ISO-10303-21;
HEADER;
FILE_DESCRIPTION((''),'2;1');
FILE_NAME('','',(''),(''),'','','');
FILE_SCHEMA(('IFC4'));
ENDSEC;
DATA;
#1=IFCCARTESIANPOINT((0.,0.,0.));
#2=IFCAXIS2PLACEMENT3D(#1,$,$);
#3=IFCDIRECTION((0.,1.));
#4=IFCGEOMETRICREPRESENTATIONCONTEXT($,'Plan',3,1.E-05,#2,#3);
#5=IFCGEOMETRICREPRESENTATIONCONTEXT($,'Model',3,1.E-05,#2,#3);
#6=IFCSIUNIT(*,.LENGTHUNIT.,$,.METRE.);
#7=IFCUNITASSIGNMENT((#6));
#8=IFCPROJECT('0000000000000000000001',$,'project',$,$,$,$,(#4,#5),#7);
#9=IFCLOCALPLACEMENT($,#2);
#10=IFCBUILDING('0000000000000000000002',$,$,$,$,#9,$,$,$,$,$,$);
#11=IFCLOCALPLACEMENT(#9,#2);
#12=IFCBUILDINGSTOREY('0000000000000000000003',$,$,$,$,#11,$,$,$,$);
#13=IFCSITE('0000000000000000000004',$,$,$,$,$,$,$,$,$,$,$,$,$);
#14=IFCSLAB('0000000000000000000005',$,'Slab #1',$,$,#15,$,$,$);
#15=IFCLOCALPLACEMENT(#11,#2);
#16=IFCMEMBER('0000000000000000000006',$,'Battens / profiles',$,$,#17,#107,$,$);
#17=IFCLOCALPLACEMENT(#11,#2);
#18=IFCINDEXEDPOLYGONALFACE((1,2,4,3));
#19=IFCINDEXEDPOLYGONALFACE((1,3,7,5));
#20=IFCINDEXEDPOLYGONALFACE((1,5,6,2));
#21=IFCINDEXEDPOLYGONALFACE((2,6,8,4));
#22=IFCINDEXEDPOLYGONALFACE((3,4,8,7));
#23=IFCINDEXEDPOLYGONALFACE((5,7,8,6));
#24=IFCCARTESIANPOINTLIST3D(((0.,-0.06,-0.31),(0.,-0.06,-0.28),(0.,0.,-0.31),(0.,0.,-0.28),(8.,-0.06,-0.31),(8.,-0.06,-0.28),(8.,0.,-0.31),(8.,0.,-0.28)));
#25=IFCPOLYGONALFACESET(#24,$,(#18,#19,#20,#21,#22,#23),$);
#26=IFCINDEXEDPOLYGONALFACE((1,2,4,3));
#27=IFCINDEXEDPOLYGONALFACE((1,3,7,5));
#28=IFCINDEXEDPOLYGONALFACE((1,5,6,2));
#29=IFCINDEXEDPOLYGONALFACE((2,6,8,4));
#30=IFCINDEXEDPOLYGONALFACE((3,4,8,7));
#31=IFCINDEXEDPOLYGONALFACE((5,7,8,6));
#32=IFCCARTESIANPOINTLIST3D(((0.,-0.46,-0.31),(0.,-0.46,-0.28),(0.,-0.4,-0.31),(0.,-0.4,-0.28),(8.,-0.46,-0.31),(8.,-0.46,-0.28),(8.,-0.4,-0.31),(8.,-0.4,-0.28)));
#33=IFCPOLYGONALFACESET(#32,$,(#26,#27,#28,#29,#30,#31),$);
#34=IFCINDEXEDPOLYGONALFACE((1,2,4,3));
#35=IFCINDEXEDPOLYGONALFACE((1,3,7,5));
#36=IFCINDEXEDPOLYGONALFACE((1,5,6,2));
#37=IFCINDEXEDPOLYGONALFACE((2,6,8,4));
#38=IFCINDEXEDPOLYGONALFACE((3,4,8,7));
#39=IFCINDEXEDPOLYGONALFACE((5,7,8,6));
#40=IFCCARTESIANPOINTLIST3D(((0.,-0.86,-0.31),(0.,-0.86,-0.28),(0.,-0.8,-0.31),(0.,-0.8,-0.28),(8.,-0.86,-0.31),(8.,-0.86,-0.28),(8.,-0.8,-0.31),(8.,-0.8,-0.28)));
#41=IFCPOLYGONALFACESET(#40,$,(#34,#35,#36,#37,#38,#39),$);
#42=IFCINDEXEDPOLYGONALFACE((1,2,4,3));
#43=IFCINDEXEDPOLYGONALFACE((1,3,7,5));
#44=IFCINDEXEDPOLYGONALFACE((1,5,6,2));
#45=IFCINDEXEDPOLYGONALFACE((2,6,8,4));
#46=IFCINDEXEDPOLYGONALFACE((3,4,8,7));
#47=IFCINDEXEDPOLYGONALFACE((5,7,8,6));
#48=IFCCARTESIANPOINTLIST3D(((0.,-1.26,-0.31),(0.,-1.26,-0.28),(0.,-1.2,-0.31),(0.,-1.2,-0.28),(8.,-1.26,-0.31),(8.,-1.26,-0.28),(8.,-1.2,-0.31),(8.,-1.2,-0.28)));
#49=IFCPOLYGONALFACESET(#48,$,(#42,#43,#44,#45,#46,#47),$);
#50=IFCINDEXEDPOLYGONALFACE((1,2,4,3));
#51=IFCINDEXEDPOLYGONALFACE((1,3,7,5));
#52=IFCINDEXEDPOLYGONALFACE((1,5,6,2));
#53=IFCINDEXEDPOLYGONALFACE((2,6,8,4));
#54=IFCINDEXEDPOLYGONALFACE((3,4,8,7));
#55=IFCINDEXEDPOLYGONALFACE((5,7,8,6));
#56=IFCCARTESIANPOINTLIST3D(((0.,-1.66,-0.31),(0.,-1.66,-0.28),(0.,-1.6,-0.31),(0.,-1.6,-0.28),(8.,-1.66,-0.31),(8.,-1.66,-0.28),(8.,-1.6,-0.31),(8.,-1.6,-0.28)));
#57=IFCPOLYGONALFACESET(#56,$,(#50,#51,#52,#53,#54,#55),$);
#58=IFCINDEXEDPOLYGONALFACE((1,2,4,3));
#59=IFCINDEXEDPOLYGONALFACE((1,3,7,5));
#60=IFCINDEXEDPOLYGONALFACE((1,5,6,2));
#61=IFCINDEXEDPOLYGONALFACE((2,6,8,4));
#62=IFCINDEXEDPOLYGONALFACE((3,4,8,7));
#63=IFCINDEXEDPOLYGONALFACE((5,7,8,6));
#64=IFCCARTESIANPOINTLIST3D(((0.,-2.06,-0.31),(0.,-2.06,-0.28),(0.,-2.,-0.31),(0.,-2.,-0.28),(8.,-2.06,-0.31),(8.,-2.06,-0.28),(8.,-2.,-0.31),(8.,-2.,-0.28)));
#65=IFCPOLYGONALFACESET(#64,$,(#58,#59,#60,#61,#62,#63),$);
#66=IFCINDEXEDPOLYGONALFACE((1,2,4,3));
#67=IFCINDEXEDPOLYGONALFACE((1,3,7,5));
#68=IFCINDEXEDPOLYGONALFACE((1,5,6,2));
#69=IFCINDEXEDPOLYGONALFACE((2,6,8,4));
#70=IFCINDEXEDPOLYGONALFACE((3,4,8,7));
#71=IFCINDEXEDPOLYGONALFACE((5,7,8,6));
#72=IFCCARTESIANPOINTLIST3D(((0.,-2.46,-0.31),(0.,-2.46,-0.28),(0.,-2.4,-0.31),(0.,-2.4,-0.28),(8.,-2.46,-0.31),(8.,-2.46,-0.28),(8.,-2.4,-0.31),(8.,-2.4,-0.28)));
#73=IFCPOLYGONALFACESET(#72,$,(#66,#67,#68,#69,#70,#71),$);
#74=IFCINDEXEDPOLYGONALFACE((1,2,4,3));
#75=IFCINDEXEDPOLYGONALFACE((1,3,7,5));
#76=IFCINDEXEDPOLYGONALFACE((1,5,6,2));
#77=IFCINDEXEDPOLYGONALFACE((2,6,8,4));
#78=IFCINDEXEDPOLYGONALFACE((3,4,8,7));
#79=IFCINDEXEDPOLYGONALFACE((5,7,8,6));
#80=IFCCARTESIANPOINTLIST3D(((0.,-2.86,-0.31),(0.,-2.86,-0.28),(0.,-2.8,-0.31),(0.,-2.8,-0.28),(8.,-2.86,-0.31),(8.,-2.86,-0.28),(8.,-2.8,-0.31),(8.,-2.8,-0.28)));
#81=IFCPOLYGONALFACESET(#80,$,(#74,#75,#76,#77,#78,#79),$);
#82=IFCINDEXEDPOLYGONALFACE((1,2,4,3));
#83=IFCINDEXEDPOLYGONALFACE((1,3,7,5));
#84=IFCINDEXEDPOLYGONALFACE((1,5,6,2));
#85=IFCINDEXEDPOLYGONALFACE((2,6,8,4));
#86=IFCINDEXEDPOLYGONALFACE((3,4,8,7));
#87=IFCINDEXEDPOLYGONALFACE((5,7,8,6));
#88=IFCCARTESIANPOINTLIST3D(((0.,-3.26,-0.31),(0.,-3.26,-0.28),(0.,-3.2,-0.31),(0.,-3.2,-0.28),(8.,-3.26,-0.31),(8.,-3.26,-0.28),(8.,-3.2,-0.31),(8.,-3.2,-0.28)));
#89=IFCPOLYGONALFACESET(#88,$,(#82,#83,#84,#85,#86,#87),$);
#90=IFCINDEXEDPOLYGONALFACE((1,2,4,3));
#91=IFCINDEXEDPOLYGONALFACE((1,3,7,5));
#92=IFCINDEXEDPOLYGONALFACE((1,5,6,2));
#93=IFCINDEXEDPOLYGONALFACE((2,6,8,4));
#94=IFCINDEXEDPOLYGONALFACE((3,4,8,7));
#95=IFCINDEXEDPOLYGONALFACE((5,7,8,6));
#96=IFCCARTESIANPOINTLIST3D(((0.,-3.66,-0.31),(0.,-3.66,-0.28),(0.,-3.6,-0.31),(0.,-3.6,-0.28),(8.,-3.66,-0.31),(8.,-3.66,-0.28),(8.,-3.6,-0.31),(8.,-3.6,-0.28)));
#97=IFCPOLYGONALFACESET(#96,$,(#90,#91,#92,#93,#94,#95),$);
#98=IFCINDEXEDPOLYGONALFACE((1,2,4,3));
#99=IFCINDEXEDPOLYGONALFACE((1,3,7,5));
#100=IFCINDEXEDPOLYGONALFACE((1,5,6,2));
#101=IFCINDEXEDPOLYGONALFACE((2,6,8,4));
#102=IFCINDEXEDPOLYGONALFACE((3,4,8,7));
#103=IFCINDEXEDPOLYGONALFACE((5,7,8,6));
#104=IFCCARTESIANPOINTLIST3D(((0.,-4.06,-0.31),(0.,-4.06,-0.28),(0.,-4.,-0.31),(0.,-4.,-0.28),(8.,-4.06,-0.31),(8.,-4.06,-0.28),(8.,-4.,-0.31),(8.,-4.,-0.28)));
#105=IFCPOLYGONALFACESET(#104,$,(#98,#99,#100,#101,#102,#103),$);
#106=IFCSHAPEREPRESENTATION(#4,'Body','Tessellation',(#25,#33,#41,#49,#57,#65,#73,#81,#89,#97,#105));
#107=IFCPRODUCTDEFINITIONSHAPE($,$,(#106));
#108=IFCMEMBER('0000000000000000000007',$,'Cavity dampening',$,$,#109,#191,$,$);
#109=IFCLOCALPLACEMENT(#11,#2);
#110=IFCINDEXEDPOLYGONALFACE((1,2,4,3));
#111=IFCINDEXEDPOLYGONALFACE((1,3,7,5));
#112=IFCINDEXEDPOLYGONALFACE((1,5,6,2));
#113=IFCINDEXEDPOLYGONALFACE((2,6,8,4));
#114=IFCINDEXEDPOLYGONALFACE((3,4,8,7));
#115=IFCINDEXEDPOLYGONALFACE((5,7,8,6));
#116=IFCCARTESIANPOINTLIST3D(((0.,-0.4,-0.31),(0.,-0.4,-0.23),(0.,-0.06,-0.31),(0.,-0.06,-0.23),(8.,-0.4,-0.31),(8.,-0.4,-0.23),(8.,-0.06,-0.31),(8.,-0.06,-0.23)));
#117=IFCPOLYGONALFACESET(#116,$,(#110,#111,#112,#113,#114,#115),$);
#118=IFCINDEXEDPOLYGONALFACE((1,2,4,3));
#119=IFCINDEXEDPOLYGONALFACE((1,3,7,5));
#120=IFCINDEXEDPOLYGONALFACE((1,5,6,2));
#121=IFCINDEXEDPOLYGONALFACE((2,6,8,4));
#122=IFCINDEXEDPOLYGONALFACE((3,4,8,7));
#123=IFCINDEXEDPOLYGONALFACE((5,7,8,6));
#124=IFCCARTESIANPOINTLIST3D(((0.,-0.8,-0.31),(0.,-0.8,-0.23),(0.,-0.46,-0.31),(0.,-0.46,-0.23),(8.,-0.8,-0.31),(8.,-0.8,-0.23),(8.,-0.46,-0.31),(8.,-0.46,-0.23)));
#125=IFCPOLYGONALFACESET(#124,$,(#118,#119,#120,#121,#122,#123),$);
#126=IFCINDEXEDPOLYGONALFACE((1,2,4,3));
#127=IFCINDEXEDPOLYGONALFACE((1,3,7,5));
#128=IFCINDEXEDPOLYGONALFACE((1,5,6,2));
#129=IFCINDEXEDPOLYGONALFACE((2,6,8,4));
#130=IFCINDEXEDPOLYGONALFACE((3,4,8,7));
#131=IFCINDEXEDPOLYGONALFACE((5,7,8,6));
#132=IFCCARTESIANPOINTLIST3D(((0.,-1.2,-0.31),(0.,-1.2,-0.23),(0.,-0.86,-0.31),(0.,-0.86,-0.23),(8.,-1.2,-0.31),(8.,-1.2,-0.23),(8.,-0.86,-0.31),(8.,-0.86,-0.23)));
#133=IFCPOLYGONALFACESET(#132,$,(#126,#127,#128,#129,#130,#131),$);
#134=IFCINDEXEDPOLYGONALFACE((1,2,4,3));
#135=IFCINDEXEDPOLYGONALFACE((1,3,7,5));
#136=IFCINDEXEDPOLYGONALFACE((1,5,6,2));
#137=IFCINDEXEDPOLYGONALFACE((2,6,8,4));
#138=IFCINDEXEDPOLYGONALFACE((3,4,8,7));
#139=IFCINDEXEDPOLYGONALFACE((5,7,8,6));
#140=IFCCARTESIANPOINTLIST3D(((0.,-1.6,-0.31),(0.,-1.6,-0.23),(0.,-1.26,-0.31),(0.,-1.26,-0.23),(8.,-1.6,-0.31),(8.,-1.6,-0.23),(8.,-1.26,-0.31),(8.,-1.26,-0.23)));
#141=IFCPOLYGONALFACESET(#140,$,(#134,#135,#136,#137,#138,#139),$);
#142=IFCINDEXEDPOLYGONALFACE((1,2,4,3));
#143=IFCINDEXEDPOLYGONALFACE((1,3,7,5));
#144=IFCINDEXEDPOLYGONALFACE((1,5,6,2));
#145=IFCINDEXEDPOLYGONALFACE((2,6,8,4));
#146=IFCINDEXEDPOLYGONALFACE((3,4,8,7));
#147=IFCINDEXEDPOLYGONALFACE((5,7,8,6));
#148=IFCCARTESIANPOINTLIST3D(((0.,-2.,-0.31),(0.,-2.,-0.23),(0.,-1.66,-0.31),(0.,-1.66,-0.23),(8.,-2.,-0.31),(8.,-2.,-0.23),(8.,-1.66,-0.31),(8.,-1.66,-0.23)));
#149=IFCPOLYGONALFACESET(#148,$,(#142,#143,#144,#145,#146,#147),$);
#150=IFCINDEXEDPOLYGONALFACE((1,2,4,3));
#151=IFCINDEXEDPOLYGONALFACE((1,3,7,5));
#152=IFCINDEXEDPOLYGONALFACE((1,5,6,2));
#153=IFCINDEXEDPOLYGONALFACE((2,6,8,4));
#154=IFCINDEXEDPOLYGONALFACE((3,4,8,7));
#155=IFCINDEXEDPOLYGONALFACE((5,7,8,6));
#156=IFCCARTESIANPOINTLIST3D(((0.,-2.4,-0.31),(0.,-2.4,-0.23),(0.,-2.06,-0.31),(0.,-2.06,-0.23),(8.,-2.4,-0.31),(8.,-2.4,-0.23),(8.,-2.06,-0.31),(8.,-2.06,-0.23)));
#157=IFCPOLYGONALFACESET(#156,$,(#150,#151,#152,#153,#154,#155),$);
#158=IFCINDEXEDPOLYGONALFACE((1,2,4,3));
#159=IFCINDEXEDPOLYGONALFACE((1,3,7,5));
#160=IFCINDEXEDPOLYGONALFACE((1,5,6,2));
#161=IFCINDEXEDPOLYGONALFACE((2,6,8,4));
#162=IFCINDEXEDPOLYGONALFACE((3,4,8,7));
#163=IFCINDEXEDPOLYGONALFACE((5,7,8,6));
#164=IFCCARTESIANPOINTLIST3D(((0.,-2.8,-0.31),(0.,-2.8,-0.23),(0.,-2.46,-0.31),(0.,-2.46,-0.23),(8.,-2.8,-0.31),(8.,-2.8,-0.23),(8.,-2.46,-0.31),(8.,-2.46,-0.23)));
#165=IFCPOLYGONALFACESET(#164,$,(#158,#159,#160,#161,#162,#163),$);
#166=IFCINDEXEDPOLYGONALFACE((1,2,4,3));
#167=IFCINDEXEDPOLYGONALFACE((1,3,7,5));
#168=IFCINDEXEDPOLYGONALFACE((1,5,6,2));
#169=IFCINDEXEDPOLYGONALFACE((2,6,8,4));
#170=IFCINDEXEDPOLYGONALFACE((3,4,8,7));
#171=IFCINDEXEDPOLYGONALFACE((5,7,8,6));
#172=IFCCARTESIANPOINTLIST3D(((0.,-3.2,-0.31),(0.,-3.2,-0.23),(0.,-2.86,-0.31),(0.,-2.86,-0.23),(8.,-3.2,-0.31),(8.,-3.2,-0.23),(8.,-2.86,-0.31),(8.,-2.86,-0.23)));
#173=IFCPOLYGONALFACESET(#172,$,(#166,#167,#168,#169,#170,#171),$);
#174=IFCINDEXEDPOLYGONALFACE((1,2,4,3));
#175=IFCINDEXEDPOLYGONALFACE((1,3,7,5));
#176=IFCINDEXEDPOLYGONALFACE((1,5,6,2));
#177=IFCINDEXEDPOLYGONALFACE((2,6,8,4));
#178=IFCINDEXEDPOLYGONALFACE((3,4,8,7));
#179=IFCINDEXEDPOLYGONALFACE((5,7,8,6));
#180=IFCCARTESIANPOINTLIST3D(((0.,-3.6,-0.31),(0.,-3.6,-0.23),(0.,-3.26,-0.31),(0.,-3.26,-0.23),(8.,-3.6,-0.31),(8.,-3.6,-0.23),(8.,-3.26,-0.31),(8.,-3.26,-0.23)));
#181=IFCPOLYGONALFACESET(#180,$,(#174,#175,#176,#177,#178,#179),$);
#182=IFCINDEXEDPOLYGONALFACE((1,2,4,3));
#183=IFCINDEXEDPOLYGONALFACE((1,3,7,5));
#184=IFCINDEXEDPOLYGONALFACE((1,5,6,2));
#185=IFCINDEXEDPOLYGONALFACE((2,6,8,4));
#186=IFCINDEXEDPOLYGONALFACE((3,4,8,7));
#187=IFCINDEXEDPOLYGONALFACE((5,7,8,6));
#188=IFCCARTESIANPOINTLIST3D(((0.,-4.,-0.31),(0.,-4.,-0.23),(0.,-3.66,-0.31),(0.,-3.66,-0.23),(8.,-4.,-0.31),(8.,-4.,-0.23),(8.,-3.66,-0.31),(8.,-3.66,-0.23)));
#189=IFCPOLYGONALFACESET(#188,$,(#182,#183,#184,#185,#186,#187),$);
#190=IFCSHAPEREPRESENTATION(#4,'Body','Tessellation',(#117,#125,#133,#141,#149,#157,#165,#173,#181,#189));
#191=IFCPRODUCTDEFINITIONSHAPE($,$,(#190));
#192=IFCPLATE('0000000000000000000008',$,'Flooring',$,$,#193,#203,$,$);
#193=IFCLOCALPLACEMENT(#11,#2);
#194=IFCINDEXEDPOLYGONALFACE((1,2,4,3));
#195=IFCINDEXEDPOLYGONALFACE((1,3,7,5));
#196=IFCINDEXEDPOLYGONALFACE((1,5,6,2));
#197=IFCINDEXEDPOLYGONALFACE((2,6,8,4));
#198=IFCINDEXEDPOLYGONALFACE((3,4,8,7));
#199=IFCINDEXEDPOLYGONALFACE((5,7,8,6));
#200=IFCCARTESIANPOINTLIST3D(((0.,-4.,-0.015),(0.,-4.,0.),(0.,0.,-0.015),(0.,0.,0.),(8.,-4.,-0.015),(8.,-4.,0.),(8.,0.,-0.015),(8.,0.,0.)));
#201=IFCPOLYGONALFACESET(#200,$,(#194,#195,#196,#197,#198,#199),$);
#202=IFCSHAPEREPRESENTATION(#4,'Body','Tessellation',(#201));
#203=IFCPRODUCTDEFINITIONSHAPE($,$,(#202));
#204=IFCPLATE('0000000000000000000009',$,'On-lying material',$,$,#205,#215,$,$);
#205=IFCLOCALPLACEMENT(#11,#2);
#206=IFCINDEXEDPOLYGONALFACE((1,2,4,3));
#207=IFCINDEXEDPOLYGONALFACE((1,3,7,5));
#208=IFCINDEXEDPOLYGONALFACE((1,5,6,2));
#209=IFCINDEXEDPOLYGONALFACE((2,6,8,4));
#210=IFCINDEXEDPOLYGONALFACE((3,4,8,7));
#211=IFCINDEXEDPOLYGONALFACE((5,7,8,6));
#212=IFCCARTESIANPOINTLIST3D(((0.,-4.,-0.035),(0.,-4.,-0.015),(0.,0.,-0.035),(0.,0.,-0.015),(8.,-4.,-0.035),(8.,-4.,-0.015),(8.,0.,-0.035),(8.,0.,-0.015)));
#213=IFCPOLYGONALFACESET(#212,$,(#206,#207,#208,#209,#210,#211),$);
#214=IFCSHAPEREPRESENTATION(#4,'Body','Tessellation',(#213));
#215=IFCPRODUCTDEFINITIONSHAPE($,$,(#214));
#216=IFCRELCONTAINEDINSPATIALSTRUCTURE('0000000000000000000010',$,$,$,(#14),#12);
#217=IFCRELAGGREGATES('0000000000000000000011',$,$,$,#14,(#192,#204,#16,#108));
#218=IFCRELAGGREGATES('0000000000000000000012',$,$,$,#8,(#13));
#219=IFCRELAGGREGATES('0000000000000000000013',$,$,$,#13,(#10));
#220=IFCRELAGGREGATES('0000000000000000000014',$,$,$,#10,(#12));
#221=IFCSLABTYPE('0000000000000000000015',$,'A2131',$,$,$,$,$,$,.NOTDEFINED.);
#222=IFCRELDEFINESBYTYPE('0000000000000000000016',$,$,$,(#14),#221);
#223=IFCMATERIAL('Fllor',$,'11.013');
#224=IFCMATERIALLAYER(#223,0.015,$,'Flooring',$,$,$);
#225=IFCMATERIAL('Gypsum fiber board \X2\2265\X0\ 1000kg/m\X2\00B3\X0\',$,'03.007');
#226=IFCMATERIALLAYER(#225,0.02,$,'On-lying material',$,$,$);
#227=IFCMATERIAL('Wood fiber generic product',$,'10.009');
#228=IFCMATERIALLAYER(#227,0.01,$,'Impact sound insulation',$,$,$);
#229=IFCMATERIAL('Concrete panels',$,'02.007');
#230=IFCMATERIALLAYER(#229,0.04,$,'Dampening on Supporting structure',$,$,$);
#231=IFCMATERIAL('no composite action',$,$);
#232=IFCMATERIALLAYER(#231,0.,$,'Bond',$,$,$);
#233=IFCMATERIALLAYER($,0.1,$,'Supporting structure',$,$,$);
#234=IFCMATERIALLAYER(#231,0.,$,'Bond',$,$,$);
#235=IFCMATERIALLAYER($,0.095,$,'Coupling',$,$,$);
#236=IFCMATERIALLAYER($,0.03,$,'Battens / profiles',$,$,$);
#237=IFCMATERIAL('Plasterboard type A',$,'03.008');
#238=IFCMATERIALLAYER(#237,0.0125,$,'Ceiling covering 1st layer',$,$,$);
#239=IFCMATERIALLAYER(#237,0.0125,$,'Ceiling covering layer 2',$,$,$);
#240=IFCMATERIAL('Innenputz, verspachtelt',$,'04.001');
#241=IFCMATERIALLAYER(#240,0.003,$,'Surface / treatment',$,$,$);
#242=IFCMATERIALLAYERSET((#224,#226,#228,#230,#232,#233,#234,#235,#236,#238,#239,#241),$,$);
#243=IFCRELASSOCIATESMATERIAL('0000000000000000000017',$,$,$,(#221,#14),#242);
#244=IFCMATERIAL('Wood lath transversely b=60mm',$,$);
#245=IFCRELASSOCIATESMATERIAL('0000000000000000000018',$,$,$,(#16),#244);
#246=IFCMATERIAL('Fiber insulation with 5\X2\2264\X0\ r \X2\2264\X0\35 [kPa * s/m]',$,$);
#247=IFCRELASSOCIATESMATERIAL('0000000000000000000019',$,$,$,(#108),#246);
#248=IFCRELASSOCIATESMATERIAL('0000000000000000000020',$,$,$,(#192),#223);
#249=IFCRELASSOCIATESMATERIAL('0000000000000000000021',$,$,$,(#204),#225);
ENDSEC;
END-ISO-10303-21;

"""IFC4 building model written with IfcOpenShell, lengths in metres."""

from ifc_helpers import new_model, si_unit, direction, frame, frame_2d, origin, origin_with_axes, place, context, project, spatial, rectangle, extrude, material, layer, layer_set, type_object, element, aggregate, save


model = new_model("IFC4")

# Units and contexts
plan_context = context("Plan", 3, precision=1e-05, world=origin(), true_north=direction((0.0, 1.0)))
model_context = context("Model", 3, precision=1e-05, world=origin(), true_north=direction((0.0, 1.0)))
ifc_project = project(units=[si_unit("LENGTHUNIT", "METRE")], contexts=[plan_context, model_context])

# Site, building, storey
site = spatial("IfcSite", under=ifc_project)
building_placement = place(None, origin())
building = spatial("IfcBuilding", under=site, at=building_placement)
storey_placement = place(building_placement, origin())
storey = spatial("IfcBuildingStorey", under=building, at=storey_placement)

# Slab, members, plates
ifc_material_1 = material(Name="Fllor", Category="11.013")
ifc_layer_1 = layer(ifc_material_1, 0.015, Name="Flooring")
ifc_material_2 = material(Name="Gypsum fiber board ≥ 1000kg/m³", Category="03.007")
ifc_layer_2 = layer(ifc_material_2, 0.02, Name="On-lying material")
ifc_material_3 = material(Name="Wood fiber generic product", Category="10.009")
ifc_layer_3 = layer(ifc_material_3, 0.01, Name="Impact sound insulation")
ifc_material_4 = material(Name="Concrete panels", Category="02.007")
ifc_layer_4 = layer(ifc_material_4, 0.04, Name="Dampening on Supporting structure")
ifc_material_5 = material(Name="no composite action")
ifc_layer_5 = layer(ifc_material_5, 0.0, Name="Bond")
ifc_layer_6 = layer(None, 0.1, Name="Supporting structure")
ifc_layer_7 = layer(ifc_material_5, 0.0, Name="Bond")
ifc_layer_8 = layer(None, 0.095, Name="Coupling")
ifc_layer_9 = layer(None, 0.03, Name="Battens / profiles")
ifc_material_6 = material(Name="Plasterboard type A", Category="03.008")
ifc_layer_10 = layer(ifc_material_6, 0.0125, Name="Ceiling covering 1st layer")
ifc_layer_11 = layer(ifc_material_6, 0.0125, Name="Ceiling covering layer 2")
ifc_material_7 = material(Name="Innenputz, verspachtelt", Category="04.001")
ifc_layer_12 = layer(ifc_material_7, 0.003, Name="Surface / treatment")
ifc_layer_set = layer_set([ifc_layer_1, ifc_layer_2, ifc_layer_3, ifc_layer_4, ifc_layer_5, ifc_layer_6, ifc_layer_7, ifc_layer_8, ifc_layer_9, ifc_layer_10, ifc_layer_11, ifc_layer_12])
slab_type = type_object("IfcSlabType", Name="A2131", PredefinedType="NOTDEFINED", material=ifc_layer_set)
slab_placement = place(None, frame((0.0, 0.0, 0.0), z_axis=(0.0, 0.0, -1.0), x_axis=(1.0, 0.0, 0.0)))
slab = element("IfcSlab", 1, at=slab_placement, inside=storey, type_object=slab_type, material=ifc_layer_set, Name="Slab #1")
ifc_material_8 = material(Name="Wood lath transversely b=60mm")
member_1_placement = place(slab_placement, origin())
member_1 = element("IfcMember", 2, at=member_1_placement, material=ifc_material_8, Name="Battens / profiles", context=plan_context, shape_type="SweptSolid", body=[
    extrude(rectangle(XDim=0.06, YDim=0.03, at=frame_2d((0.03, 0.015), x_axis=(1.0, 0.0))), frame((0.0, 0.0, 0.28), z_axis=(1.0, 0.0, 0.0), x_axis=(0.0, 1.0, 0.0)), (0.0, 0.0, 1.0), 8.0),
    extrude(rectangle(XDim=0.06, YDim=0.03, at=frame_2d((0.03, 0.015), x_axis=(1.0, 0.0))), frame((0.0, 0.4, 0.28), z_axis=(1.0, 0.0, 0.0), x_axis=(0.0, 1.0, 0.0)), (0.0, 0.0, 1.0), 8.0),
    extrude(rectangle(XDim=0.06, YDim=0.03, at=frame_2d((0.03, 0.015), x_axis=(1.0, 0.0))), frame((0.0, 0.8, 0.28), z_axis=(1.0, 0.0, 0.0), x_axis=(0.0, 1.0, 0.0)), (0.0, 0.0, 1.0), 8.0),
    extrude(rectangle(XDim=0.06, YDim=0.03, at=frame_2d((0.03, 0.015), x_axis=(1.0, 0.0))), frame((0.0, 1.2, 0.28), z_axis=(1.0, 0.0, 0.0), x_axis=(0.0, 1.0, 0.0)), (0.0, 0.0, 1.0), 8.0),
    extrude(rectangle(XDim=0.06, YDim=0.03, at=frame_2d((0.03, 0.015), x_axis=(1.0, 0.0))), frame((0.0, 1.6, 0.28), z_axis=(1.0, 0.0, 0.0), x_axis=(0.0, 1.0, 0.0)), (0.0, 0.0, 1.0), 8.0),
    extrude(rectangle(XDim=0.06, YDim=0.03, at=frame_2d((0.03, 0.015), x_axis=(1.0, 0.0))), frame((0.0, 2.0, 0.28), z_axis=(1.0, 0.0, 0.0), x_axis=(0.0, 1.0, 0.0)), (0.0, 0.0, 1.0), 8.0),
    extrude(rectangle(XDim=0.06, YDim=0.03, at=frame_2d((0.03, 0.015), x_axis=(1.0, 0.0))), frame((0.0, 2.4, 0.28), z_axis=(1.0, 0.0, 0.0), x_axis=(0.0, 1.0, 0.0)), (0.0, 0.0, 1.0), 8.0),
    extrude(rectangle(XDim=0.06, YDim=0.03, at=frame_2d((0.03, 0.015), x_axis=(1.0, 0.0))), frame((0.0, 2.8, 0.28), z_axis=(1.0, 0.0, 0.0), x_axis=(0.0, 1.0, 0.0)), (0.0, 0.0, 1.0), 8.0),
    extrude(rectangle(XDim=0.06, YDim=0.03, at=frame_2d((0.03, 0.015), x_axis=(1.0, 0.0))), frame((0.0, 3.2, 0.28), z_axis=(1.0, 0.0, 0.0), x_axis=(0.0, 1.0, 0.0)), (0.0, 0.0, 1.0), 8.0),
    extrude(rectangle(XDim=0.06, YDim=0.03, at=frame_2d((0.03, 0.015), x_axis=(1.0, 0.0))), frame((0.0, 3.6, 0.28), z_axis=(1.0, 0.0, 0.0), x_axis=(0.0, 1.0, 0.0)), (0.0, 0.0, 1.0), 8.0),
    extrude(rectangle(XDim=0.06, YDim=0.03, at=frame_2d((0.03, 0.015), x_axis=(1.0, 0.0))), frame((0.0, 4.0, 0.28), z_axis=(1.0, 0.0, 0.0), x_axis=(0.0, 1.0, 0.0)), (0.0, 0.0, 1.0), 8.0),
])
ifc_material_9 = material(Name="Fiber insulation with 5≤ r ≤35 [kPa * s/m]")
member_2_placement = place(slab_placement, origin())
member_2 = element("IfcMember", 3, at=member_2_placement, material=ifc_material_9, Name="Cavity dampening", context=plan_context, shape_type="SweptSolid", body=[
    extrude(rectangle(XDim=0.34, YDim=0.08, at=frame_2d((0.17, 0.04), x_axis=(1.0, 0.0))), frame((0.0, 0.06, 0.23), z_axis=(1.0, 0.0, 0.0), x_axis=(0.0, 1.0, 0.0)), (0.0, 0.0, 1.0), 8.0),
    extrude(rectangle(XDim=0.34, YDim=0.08, at=frame_2d((0.17, 0.04), x_axis=(1.0, 0.0))), frame((0.0, 0.46, 0.23), z_axis=(1.0, 0.0, 0.0), x_axis=(0.0, 1.0, 0.0)), (0.0, 0.0, 1.0), 8.0),
    extrude(rectangle(XDim=0.34, YDim=0.08, at=frame_2d((0.17, 0.04), x_axis=(1.0, 0.0))), frame((0.0, 0.86, 0.23), z_axis=(1.0, 0.0, 0.0), x_axis=(0.0, 1.0, 0.0)), (0.0, 0.0, 1.0), 8.0),
    extrude(rectangle(XDim=0.34, YDim=0.08, at=frame_2d((0.17, 0.04), x_axis=(1.0, 0.0))), frame((0.0, 1.26, 0.23), z_axis=(1.0, 0.0, 0.0), x_axis=(0.0, 1.0, 0.0)), (0.0, 0.0, 1.0), 8.0),
    extrude(rectangle(XDim=0.34, YDim=0.08, at=frame_2d((0.17, 0.04), x_axis=(1.0, 0.0))), frame((0.0, 1.66, 0.23), z_axis=(1.0, 0.0, 0.0), x_axis=(0.0, 1.0, 0.0)), (0.0, 0.0, 1.0), 8.0),
    extrude(rectangle(XDim=0.34, YDim=0.08, at=frame_2d((0.17, 0.04), x_axis=(1.0, 0.0))), frame((0.0, 2.06, 0.23), z_axis=(1.0, 0.0, 0.0), x_axis=(0.0, 1.0, 0.0)), (0.0, 0.0, 1.0), 8.0),
    extrude(rectangle(XDim=0.34, YDim=0.08, at=frame_2d((0.17, 0.04), x_axis=(1.0, 0.0))), frame((0.0, 2.46, 0.23), z_axis=(1.0, 0.0, 0.0), x_axis=(0.0, 1.0, 0.0)), (0.0, 0.0, 1.0), 8.0),
    extrude(rectangle(XDim=0.34, YDim=0.08, at=frame_2d((0.17, 0.04), x_axis=(1.0, 0.0))), frame((0.0, 2.86, 0.23), z_axis=(1.0, 0.0, 0.0), x_axis=(0.0, 1.0, 0.0)), (0.0, 0.0, 1.0), 8.0),
    extrude(rectangle(XDim=0.34, YDim=0.08, at=frame_2d((0.17, 0.04), x_axis=(1.0, 0.0))), frame((0.0, 3.26, 0.23), z_axis=(1.0, 0.0, 0.0), x_axis=(0.0, 1.0, 0.0)), (0.0, 0.0, 1.0), 8.0),
    extrude(rectangle(XDim=0.34, YDim=0.08, at=frame_2d((0.17, 0.04), x_axis=(1.0, 0.0))), frame((0.0, 3.66, 0.23), z_axis=(1.0, 0.0, 0.0), x_axis=(0.0, 1.0, 0.0)), (0.0, 0.0, 1.0), 8.0),
])
plate_1_placement = place(slab_placement, origin())
plate_1 = element("IfcPlate", 4, at=plate_1_placement, material=ifc_material_1, Name="Flooring", context=plan_context, shape_type="SweptSolid", body=[
    extrude(rectangle(XDim=8.0, YDim=4.0, at=frame_2d((4.0, 2.0), x_axis=(1.0, 0.0))), origin_with_axes(), (0.0, 0.0, 1.0), 0.015),
])
plate_2_placement = place(slab_placement, origin())
plate_2 = element("IfcPlate", 5, at=plate_2_placement, material=ifc_material_2, Name="On-lying material", context=plan_context, shape_type="SweptSolid", body=[
    extrude(rectangle(XDim=8.0, YDim=4.0, at=frame_2d((4.0, 2.0), x_axis=(1.0, 0.0))), frame((0.0, 0.0, 0.015), z_axis=(0.0, 0.0, 1.0), x_axis=(1.0, 0.0, 0.0)), (0.0, 0.0, 1.0), 0.02),
])
aggregate(slab, [plate_1, plate_2, member_1, member_2])

save(model, "model.ifc")
